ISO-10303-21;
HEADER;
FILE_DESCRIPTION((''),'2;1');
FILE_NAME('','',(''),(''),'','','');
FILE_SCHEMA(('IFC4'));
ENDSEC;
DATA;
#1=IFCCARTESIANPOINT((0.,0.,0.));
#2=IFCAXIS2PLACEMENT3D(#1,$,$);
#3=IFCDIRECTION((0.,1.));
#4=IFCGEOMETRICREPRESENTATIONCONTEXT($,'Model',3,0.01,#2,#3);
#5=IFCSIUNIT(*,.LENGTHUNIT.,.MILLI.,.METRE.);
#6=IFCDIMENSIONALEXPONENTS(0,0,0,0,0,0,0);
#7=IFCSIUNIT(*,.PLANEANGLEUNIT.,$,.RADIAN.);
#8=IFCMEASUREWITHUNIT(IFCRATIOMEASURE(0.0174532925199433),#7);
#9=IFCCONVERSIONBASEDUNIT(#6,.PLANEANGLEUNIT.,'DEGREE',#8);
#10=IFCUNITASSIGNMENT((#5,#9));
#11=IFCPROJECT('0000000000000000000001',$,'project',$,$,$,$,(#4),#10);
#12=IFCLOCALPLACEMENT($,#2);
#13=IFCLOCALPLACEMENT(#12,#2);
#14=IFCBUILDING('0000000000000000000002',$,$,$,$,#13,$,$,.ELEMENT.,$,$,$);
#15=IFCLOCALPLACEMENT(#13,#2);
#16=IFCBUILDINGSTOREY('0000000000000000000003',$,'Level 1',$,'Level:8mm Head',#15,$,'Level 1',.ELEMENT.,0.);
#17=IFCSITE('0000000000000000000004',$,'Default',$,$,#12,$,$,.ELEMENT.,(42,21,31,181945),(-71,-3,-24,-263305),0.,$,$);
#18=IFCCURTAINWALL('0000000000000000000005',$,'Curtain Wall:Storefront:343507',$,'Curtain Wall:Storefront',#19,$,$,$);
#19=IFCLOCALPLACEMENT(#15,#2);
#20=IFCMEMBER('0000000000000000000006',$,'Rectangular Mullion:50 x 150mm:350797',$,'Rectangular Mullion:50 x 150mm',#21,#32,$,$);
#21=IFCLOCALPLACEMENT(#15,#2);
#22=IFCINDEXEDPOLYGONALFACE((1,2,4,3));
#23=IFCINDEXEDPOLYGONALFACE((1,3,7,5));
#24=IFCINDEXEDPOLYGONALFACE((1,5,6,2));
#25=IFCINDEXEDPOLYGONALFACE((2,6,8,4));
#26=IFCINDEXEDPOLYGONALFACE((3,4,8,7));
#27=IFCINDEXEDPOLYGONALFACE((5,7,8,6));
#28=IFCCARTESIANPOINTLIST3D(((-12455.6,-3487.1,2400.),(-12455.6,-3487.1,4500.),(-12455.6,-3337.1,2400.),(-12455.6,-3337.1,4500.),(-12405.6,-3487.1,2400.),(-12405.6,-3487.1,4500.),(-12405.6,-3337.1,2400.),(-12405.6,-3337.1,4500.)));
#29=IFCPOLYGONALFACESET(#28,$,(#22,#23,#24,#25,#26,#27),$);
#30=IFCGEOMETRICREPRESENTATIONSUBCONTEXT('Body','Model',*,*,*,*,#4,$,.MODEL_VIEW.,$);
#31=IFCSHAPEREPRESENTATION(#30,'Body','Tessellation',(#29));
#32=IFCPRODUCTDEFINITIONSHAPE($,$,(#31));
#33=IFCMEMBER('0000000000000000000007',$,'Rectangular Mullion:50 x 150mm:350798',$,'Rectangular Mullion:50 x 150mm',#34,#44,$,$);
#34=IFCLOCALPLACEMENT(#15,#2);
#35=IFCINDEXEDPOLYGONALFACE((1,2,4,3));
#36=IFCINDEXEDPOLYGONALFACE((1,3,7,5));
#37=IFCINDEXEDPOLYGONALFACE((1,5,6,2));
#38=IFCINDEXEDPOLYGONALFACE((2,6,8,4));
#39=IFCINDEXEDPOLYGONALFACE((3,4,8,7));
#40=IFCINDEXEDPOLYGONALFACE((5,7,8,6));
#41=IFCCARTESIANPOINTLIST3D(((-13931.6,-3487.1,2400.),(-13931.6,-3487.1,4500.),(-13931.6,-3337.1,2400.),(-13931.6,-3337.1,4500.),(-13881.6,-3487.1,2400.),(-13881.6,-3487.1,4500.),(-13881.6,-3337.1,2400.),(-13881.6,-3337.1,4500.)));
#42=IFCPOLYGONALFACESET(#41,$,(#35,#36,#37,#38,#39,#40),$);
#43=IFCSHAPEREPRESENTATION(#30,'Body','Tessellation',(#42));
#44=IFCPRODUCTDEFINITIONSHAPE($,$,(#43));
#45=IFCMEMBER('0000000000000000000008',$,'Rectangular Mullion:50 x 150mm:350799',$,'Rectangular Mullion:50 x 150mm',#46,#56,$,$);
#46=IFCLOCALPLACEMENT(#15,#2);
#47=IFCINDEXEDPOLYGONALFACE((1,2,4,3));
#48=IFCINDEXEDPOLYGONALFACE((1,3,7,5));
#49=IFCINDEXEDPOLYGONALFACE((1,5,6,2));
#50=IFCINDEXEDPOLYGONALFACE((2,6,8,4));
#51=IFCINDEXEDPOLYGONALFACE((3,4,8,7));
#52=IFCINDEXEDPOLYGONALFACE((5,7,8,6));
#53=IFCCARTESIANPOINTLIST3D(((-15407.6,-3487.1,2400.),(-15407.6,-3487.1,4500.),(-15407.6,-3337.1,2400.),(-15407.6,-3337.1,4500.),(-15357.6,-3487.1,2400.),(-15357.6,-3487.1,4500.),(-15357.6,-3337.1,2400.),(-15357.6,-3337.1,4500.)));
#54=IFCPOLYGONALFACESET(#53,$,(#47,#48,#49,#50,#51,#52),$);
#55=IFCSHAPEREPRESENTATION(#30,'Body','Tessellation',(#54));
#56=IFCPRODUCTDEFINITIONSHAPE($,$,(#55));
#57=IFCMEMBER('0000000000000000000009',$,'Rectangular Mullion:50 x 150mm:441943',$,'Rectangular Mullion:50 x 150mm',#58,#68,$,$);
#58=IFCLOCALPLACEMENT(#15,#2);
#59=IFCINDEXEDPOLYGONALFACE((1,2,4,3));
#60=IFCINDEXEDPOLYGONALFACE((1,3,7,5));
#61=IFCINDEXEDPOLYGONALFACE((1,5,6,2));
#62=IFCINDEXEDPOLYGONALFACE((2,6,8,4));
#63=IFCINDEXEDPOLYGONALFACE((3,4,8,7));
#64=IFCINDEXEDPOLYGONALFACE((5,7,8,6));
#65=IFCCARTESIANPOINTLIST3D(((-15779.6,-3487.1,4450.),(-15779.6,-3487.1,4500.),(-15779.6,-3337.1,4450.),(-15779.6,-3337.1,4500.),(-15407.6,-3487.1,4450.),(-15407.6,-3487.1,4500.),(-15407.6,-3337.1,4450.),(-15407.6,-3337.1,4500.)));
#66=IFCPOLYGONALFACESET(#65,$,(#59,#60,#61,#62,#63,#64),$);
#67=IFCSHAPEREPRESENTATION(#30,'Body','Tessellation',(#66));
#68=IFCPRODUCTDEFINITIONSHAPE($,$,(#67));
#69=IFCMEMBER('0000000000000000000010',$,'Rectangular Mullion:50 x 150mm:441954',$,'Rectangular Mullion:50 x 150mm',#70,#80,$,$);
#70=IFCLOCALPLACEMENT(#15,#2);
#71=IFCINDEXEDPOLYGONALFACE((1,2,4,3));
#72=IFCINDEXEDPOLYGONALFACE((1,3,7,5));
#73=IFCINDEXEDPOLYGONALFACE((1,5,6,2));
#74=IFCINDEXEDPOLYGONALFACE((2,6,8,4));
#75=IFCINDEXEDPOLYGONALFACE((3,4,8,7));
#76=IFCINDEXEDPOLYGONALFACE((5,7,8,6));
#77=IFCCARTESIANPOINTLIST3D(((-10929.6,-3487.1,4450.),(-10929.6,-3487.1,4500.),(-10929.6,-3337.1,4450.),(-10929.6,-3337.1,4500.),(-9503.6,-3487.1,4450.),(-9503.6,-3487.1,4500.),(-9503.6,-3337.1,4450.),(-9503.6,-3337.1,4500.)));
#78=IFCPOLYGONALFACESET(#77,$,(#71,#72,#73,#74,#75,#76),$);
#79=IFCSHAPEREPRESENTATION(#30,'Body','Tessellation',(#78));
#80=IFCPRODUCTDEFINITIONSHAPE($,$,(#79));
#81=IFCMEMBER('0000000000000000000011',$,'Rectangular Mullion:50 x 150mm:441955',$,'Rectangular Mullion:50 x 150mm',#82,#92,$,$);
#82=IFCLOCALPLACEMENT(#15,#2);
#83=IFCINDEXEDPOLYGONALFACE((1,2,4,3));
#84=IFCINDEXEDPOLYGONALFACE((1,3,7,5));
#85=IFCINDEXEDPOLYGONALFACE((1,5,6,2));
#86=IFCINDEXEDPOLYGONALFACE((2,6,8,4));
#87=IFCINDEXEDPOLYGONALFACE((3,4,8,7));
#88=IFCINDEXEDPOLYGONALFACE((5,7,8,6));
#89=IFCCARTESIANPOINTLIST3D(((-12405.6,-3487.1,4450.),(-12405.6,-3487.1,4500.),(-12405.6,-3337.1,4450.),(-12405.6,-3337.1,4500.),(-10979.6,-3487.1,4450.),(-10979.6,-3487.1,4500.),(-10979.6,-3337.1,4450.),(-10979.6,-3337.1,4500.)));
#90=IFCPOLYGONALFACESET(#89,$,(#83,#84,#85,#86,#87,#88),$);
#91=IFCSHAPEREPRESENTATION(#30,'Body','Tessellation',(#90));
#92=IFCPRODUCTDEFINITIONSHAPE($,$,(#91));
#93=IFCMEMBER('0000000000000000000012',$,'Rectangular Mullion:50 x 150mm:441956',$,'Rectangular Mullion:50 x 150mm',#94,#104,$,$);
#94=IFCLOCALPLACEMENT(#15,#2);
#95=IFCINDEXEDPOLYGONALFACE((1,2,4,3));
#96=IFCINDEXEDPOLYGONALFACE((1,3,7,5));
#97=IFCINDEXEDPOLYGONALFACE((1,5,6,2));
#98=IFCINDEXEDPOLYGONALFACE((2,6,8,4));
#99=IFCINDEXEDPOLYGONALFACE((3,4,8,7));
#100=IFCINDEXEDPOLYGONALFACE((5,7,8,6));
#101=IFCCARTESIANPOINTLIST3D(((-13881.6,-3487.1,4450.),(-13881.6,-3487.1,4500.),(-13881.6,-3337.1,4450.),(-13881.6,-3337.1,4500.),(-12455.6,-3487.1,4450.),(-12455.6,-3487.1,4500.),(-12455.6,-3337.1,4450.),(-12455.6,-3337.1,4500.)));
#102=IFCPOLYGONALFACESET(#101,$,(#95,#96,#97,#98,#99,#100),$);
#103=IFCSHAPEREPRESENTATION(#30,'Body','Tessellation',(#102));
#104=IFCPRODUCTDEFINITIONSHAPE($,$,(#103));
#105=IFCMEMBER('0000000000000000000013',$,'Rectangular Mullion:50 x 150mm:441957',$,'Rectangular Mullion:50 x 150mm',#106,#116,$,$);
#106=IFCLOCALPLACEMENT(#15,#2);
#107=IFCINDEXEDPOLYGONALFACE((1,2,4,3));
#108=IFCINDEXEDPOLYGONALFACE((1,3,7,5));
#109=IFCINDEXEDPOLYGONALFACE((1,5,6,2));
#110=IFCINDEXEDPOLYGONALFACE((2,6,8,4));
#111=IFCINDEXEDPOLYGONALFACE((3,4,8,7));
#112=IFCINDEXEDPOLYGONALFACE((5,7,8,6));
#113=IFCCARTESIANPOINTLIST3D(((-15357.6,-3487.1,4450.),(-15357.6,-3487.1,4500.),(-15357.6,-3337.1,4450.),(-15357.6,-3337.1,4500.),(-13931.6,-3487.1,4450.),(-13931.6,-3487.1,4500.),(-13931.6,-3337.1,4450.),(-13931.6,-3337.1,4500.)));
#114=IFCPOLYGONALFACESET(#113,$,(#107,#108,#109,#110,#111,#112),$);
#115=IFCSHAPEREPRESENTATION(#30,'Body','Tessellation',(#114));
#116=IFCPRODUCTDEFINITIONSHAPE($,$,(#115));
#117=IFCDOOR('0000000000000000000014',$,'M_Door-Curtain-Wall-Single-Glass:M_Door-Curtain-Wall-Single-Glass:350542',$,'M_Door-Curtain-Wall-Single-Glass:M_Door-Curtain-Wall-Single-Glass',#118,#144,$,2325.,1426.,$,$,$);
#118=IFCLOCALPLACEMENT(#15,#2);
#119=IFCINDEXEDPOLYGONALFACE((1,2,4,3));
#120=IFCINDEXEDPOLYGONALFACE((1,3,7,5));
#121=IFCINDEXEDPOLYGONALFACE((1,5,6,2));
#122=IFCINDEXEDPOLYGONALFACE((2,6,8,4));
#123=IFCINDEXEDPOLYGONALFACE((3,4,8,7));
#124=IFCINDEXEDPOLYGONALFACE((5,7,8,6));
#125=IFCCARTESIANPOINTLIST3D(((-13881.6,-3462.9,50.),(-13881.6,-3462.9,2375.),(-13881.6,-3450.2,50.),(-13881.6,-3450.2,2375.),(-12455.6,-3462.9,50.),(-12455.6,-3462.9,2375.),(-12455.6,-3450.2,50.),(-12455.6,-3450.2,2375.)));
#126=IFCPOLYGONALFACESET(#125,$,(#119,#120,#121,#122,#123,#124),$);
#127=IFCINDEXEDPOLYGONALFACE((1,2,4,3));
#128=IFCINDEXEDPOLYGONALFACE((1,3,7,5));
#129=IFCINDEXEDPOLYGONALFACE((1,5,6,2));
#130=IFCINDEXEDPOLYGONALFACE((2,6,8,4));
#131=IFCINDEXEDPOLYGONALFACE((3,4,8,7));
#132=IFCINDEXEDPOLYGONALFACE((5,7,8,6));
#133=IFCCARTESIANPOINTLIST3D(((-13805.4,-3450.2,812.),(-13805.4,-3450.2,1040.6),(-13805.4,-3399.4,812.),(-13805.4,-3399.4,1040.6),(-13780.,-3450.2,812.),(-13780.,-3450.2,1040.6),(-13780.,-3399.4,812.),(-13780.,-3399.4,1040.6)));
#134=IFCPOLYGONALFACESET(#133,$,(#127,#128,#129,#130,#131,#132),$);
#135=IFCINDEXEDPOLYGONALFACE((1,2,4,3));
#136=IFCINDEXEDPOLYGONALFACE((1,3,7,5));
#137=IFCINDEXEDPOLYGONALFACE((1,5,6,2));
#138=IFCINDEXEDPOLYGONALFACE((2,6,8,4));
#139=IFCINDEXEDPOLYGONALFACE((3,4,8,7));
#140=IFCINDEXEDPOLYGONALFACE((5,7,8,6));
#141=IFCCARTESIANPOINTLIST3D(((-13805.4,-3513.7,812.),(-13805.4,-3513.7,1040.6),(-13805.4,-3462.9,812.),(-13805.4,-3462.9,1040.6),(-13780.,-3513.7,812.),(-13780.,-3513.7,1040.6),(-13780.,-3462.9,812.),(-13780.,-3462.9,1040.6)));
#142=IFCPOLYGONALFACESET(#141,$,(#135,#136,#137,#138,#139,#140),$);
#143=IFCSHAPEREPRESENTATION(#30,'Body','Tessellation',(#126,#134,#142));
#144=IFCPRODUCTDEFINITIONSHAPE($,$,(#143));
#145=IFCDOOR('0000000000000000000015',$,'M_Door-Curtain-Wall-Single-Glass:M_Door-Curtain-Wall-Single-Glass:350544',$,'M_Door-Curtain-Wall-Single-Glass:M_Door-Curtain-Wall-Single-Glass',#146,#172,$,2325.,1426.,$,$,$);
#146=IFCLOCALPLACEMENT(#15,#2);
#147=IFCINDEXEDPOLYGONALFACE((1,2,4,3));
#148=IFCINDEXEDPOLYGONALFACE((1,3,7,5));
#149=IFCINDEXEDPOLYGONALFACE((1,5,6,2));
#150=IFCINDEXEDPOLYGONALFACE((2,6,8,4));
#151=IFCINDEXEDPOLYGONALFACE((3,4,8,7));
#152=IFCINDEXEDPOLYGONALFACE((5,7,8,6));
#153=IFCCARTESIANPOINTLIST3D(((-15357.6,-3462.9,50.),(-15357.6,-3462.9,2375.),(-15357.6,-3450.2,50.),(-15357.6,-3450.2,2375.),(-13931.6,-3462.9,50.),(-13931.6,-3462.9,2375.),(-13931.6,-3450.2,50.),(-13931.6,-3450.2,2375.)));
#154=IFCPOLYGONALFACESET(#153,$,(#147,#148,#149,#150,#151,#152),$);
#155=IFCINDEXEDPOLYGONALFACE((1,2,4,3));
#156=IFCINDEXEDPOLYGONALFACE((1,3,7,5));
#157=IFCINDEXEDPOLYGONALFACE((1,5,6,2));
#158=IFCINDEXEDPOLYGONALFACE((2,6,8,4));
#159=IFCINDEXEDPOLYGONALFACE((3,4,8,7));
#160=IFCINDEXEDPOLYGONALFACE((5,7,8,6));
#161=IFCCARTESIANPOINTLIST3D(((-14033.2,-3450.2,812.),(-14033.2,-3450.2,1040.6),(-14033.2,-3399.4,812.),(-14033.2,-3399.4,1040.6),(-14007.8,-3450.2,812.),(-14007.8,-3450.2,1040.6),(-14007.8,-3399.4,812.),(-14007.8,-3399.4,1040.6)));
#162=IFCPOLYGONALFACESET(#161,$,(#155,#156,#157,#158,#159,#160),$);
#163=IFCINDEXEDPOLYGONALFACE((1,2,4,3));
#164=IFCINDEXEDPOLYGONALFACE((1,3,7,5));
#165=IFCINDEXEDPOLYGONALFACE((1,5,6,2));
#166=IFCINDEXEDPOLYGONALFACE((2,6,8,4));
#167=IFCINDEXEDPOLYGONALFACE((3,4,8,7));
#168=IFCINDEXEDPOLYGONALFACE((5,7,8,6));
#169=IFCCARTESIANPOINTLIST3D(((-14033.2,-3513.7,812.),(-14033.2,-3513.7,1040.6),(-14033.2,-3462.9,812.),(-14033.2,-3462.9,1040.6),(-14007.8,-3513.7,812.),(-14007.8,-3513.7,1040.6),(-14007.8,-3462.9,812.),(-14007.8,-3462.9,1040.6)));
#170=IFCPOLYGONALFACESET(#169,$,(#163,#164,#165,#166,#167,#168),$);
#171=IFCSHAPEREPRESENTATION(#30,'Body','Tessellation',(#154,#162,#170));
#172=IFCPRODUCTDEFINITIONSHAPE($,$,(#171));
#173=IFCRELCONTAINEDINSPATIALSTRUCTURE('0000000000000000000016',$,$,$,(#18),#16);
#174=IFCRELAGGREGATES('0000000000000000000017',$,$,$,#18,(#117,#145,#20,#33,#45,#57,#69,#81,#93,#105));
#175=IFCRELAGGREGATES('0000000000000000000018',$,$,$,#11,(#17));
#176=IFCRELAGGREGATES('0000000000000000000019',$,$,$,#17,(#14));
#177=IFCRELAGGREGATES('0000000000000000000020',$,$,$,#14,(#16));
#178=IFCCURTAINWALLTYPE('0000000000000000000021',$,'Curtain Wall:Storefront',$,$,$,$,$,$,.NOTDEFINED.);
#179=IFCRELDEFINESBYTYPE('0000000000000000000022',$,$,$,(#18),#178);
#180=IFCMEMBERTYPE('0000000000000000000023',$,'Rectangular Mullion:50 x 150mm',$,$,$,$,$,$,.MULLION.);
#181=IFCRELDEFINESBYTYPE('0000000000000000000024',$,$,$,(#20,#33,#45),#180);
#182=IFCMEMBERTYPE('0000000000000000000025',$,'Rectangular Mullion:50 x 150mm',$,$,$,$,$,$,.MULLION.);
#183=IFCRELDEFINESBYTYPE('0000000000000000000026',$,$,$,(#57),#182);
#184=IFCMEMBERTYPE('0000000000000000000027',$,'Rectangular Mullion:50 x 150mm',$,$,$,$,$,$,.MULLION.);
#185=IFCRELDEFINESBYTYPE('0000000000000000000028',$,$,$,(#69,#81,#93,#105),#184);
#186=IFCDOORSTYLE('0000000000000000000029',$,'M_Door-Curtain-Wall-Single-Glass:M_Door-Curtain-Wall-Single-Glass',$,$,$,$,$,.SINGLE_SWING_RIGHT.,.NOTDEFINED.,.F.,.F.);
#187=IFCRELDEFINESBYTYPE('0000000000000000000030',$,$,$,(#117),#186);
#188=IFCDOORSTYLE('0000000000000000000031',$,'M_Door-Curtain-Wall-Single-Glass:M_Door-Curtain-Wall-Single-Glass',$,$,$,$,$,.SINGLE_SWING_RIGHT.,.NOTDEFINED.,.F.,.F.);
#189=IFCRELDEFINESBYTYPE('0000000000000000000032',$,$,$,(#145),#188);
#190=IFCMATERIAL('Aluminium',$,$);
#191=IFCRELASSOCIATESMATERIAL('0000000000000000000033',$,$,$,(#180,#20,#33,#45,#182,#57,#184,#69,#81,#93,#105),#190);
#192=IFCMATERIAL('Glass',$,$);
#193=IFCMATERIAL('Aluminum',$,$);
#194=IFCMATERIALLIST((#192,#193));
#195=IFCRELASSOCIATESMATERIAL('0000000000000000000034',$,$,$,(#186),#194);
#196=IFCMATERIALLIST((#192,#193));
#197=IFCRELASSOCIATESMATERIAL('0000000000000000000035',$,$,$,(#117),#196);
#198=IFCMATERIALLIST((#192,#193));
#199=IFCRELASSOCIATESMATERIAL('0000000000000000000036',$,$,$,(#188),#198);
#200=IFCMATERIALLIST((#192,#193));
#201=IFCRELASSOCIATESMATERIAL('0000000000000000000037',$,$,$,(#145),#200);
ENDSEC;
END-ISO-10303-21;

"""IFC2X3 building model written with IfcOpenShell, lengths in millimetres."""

from ifc_helpers import new_model, entity, si_unit, converted_unit, direction, frame, frame_2d, origin, origin_2d_with_axis, place, context, subcontext, project, spatial, rectangle, extrude, source, transform, mapped, material, material_list, type_object, type_shapes, element, aggregate, save


model = new_model("IFC2X3")

# Units and contexts
model_context = context("Model", 3, precision=0.01, world=origin(), true_north=direction((0.0, 1.0)))
body_context = subcontext(model_context, "Body", "Model", "MODEL_VIEW")
ifc_project = project(units=[si_unit("LENGTHUNIT", "METRE", prefix="MILLI"), converted_unit("PLANEANGLEUNIT", "DEGREE", entity("IfcRatioMeasure", 0.0174532925199433), si_unit("PLANEANGLEUNIT", "RADIAN"), dimensions=[0, 0, 0, 0, 0, 0, 0])], contexts=[model_context])

# Site, building, storey
site_placement = place(None, frame((0.0, 0.0, 0.0)))
site = spatial("IfcSite", under=ifc_project, at=site_placement, Name="Default", CompositionType="ELEMENT", RefLatitude=(42, 21, 31, 181945), RefLongitude=(-71, -3, -24, -263305), RefElevation=0.0)
building_placement = place(site_placement, origin())
building = spatial("IfcBuilding", under=site, at=building_placement, CompositionType="ELEMENT")
storey_placement = place(building_placement, origin())
storey = spatial("IfcBuildingStorey", under=building, at=storey_placement, Name="Level 1", ObjectType="Level:8mm Head", LongName="Level 1", CompositionType="ELEMENT", Elevation=0.0)

# Curtain wall, members, doors
curtain_wall_type = type_object("IfcCurtainWallType", Name="Curtain Wall:Storefront", PredefinedType="NOTDEFINED")
curtain_wall_placement = place(storey_placement, origin())
curtain_wall = element("IfcCurtainWall", 1, at=curtain_wall_placement, inside=storey, type_object=curtain_wall_type, Name="Curtain Wall:Storefront:343507", ObjectType="Curtain Wall:Storefront")
ifc_material_1 = material(Name="Aluminium")
member_type_1 = type_object("IfcMemberType", Name="Rectangular Mullion:50 x 150mm", PredefinedType="MULLION", material=ifc_material_1)
shared_shape_1 = source(origin(), body_context, "Body", "SweptSolid", [
    extrude(rectangle(XDim=150.0, YDim=50.0, at=origin_2d_with_axis()), frame((0.0, 0.0, -2100.0), z_axis=(0.0, 0.0, 1.0), x_axis=(0.0, -1.0, 0.0)), (0.0, 0.0, 1.0), 2100.0),
])
type_shapes(member_type_1, [shared_shape_1])
member_1_placement = place(storey_placement, frame((-12430.6, -3412.1, 2400.0), z_axis=(0.0, 0.0, -1.0), x_axis=(-1.0, 0.0, 0.0)))
member_1 = element("IfcMember", 2, at=member_1_placement, type_object=member_type_1, material=ifc_material_1, Name="Rectangular Mullion:50 x 150mm:350797", ObjectType="Rectangular Mullion:50 x 150mm", context=body_context, shape_type="MappedRepresentation", body=[
    mapped(shared_shape_1, transform((0.0, 0.0, 0.0), scale=1.0)),
])
member_2_placement = place(storey_placement, frame((-13906.6, -3412.1, 2400.0), z_axis=(0.0, 0.0, -1.0), x_axis=(-1.0, 0.0, 0.0)))
member_2 = element("IfcMember", 3, at=member_2_placement, type_object=member_type_1, material=ifc_material_1, Name="Rectangular Mullion:50 x 150mm:350798", ObjectType="Rectangular Mullion:50 x 150mm", context=body_context, shape_type="MappedRepresentation", body=[
    mapped(shared_shape_1, transform((0.0, 0.0, 0.0), scale=1.0)),
])
member_3_placement = place(storey_placement, frame((-15382.6, -3412.1, 2400.0), z_axis=(0.0, 0.0, -1.0), x_axis=(-1.0, 0.0, 0.0)))
member_3 = element("IfcMember", 4, at=member_3_placement, type_object=member_type_1, material=ifc_material_1, Name="Rectangular Mullion:50 x 150mm:350799", ObjectType="Rectangular Mullion:50 x 150mm", context=body_context, shape_type="MappedRepresentation", body=[
    mapped(shared_shape_1, transform((0.0, 0.0, 0.0), scale=1.0)),
])
member_type_2 = type_object("IfcMemberType", Name="Rectangular Mullion:50 x 150mm", PredefinedType="MULLION", material=ifc_material_1)
shared_shape_2 = source(origin(), body_context, "Body", "SweptSolid", [
    extrude(rectangle(XDim=150.0, YDim=50.0, at=origin_2d_with_axis()), frame((-25.0, 0.0, -372.0), z_axis=(0.0, 0.0, 1.0), x_axis=(0.0, -1.0, 0.0)), (0.0, 0.0, 1.0), 372.0),
])
type_shapes(member_type_2, [shared_shape_2])
member_4_placement = place(storey_placement, frame((-15779.6, -3412.1, 4500.0), z_axis=(-1.0, 0.0, 0.0), x_axis=(0.0, 0.0, 1.0)))
member_4 = element("IfcMember", 5, at=member_4_placement, type_object=member_type_2, material=ifc_material_1, Name="Rectangular Mullion:50 x 150mm:441943", ObjectType="Rectangular Mullion:50 x 150mm", context=body_context, shape_type="MappedRepresentation", body=[
    mapped(shared_shape_2, transform((0.0, 0.0, 0.0), scale=1.0)),
])
member_type_3 = type_object("IfcMemberType", Name="Rectangular Mullion:50 x 150mm", PredefinedType="MULLION", material=ifc_material_1)
shared_shape_3 = source(origin(), body_context, "Body", "SweptSolid", [
    extrude(rectangle(XDim=150.0, YDim=50.0, at=origin_2d_with_axis()), frame((-25.0, 0.0, -1426.0), z_axis=(0.0, 0.0, 1.0), x_axis=(0.0, -1.0, 0.0)), (0.0, 0.0, 1.0), 1426.0),
])
type_shapes(member_type_3, [shared_shape_3])
member_5_placement = place(storey_placement, frame((-10929.6, -3412.1, 4500.0), z_axis=(-1.0, 0.0, 0.0), x_axis=(0.0, 0.0, 1.0)))
member_5 = element("IfcMember", 6, at=member_5_placement, type_object=member_type_3, material=ifc_material_1, Name="Rectangular Mullion:50 x 150mm:441954", ObjectType="Rectangular Mullion:50 x 150mm", context=body_context, shape_type="MappedRepresentation", body=[
    mapped(shared_shape_3, transform((0.0, 0.0, 0.0), scale=1.0)),
])
member_6_placement = place(storey_placement, frame((-12405.6, -3412.1, 4500.0), z_axis=(-1.0, 0.0, 0.0), x_axis=(0.0, 0.0, 1.0)))
member_6 = element("IfcMember", 7, at=member_6_placement, type_object=member_type_3, material=ifc_material_1, Name="Rectangular Mullion:50 x 150mm:441955", ObjectType="Rectangular Mullion:50 x 150mm", context=body_context, shape_type="MappedRepresentation", body=[
    mapped(shared_shape_3, transform((0.0, 0.0, 0.0), scale=1.0)),
])
member_7_placement = place(storey_placement, frame((-13881.6, -3412.1, 4500.0), z_axis=(-1.0, 0.0, 0.0), x_axis=(0.0, 0.0, 1.0)))
member_7 = element("IfcMember", 8, at=member_7_placement, type_object=member_type_3, material=ifc_material_1, Name="Rectangular Mullion:50 x 150mm:441956", ObjectType="Rectangular Mullion:50 x 150mm", context=body_context, shape_type="MappedRepresentation", body=[
    mapped(shared_shape_3, transform((0.0, 0.0, 0.0), scale=1.0)),
])
member_8_placement = place(storey_placement, frame((-15357.6, -3412.1, 4500.0), z_axis=(-1.0, 0.0, 0.0), x_axis=(0.0, 0.0, 1.0)))
member_8 = element("IfcMember", 9, at=member_8_placement, type_object=member_type_3, material=ifc_material_1, Name="Rectangular Mullion:50 x 150mm:441957", ObjectType="Rectangular Mullion:50 x 150mm", context=body_context, shape_type="MappedRepresentation", body=[
    mapped(shared_shape_3, transform((0.0, 0.0, 0.0), scale=1.0)),
])
ifc_material_2 = material(Name="Glass")
ifc_material_3 = material(Name="Aluminum")
ifc_material_list_1 = material_list([ifc_material_2, ifc_material_3])
ifc_material_list_2 = material_list([ifc_material_2, ifc_material_3])
door_style_1 = type_object("IfcDoorStyle", Name="M_Door-Curtain-Wall-Single-Glass:M_Door-Curtain-Wall-Single-Glass", ConstructionType="NOTDEFINED", OperationType="SINGLE_SWING_RIGHT", ParameterTakesPrecedence=False, Sizeable=False, material=ifc_material_list_2)
shared_shape_4 = source(origin(), body_context, "Body", "SweptSolid", [
    extrude(rectangle(XDim=12.7, YDim=1426.0, at=frame_2d((0.0, 0.0), x_axis=(1.0, 0.0))), frame((0.0, -44.5, 0.0), z_axis=(0.0, 0.0, 1.0), x_axis=(0.0, 1.0, 0.0)), (0.0, 0.0, 1.0), 2325.0),
    extrude(rectangle(XDim=25.4, YDim=50.8, at=origin_2d_with_axis()), frame((-624.1, -12.7, 762.0), z_axis=(0.0, 0.0, 1.0), x_axis=(-1.0, 0.0, 0.0)), (0.0, 0.0, 1.0), 228.6),
    extrude(rectangle(XDim=25.4, YDim=50.8, at=frame_2d((0.0, 0.0), x_axis=(1.0, 0.0))), frame((-624.1, -76.2, 762.0)), (0.0, 0.0, 1.0), 228.6),
])
type_shapes(door_style_1, [shared_shape_4])
door_1_placement = place(curtain_wall_placement, frame((-13168.6, -3412.1, 50.0)))
door_1 = element("IfcDoor", 10, at=door_1_placement, type_object=door_style_1, material=ifc_material_list_1, Name="M_Door-Curtain-Wall-Single-Glass:M_Door-Curtain-Wall-Single-Glass:350542", ObjectType="M_Door-Curtain-Wall-Single-Glass:M_Door-Curtain-Wall-Single-Glass", OverallHeight=2325.0, OverallWidth=1426.0, context=body_context, shape_type="MappedRepresentation", body=[
    mapped(shared_shape_4, transform((0.0, 0.0, 0.0), scale=1.0)),
])
ifc_material_list_3 = material_list([ifc_material_2, ifc_material_3])
ifc_material_list_4 = material_list([ifc_material_2, ifc_material_3])
door_style_2 = type_object("IfcDoorStyle", Name="M_Door-Curtain-Wall-Single-Glass:M_Door-Curtain-Wall-Single-Glass", ConstructionType="NOTDEFINED", OperationType="SINGLE_SWING_RIGHT", ParameterTakesPrecedence=False, Sizeable=False, material=ifc_material_list_4)
shared_shape_5 = source(origin(), body_context, "Body", "SweptSolid", [
    extrude(rectangle(XDim=1426.0, YDim=12.7, at=frame_2d((0.0, 0.0), x_axis=(1.0, 0.0))), frame((0.0, 44.5, 0.0), z_axis=(0.0, 0.0, 1.0), x_axis=(-1.0, 0.0, 0.0)), (0.0, 0.0, 1.0), 2325.0),
    extrude(rectangle(XDim=50.8, YDim=25.4, at=origin_2d_with_axis()), frame((-624.1, 12.7, 762.0), z_axis=(0.0, 0.0, 1.0), x_axis=(0.0, 1.0, 0.0)), (0.0, 0.0, 1.0), 228.6),
    extrude(rectangle(XDim=50.8, YDim=25.4, at=frame_2d((0.0, 0.0), x_axis=(1.0, 0.0))), frame((-624.1, 76.2, 762.0), z_axis=(0.0, 0.0, 1.0), x_axis=(0.0, -1.0, 0.0)), (0.0, 0.0, 1.0), 228.6),
])
type_shapes(door_style_2, [shared_shape_5])
door_2_placement = place(curtain_wall_placement, frame((-14644.6, -3412.1, 50.0), z_axis=(0.0, 0.0, 1.0), x_axis=(-1.0, 0.0, 0.0)))
door_2 = element("IfcDoor", 11, at=door_2_placement, type_object=door_style_2, material=ifc_material_list_3, Name="M_Door-Curtain-Wall-Single-Glass:M_Door-Curtain-Wall-Single-Glass:350544", ObjectType="M_Door-Curtain-Wall-Single-Glass:M_Door-Curtain-Wall-Single-Glass", OverallHeight=2325.0, OverallWidth=1426.0, context=body_context, shape_type="MappedRepresentation", body=[
    mapped(shared_shape_5, transform((0.0, 0.0, 0.0), scale=1.0)),
])
aggregate(curtain_wall, [door_1, door_2, member_1, member_2, member_3, member_4, member_5, member_6, member_7, member_8])

save(model, "model.ifc")
